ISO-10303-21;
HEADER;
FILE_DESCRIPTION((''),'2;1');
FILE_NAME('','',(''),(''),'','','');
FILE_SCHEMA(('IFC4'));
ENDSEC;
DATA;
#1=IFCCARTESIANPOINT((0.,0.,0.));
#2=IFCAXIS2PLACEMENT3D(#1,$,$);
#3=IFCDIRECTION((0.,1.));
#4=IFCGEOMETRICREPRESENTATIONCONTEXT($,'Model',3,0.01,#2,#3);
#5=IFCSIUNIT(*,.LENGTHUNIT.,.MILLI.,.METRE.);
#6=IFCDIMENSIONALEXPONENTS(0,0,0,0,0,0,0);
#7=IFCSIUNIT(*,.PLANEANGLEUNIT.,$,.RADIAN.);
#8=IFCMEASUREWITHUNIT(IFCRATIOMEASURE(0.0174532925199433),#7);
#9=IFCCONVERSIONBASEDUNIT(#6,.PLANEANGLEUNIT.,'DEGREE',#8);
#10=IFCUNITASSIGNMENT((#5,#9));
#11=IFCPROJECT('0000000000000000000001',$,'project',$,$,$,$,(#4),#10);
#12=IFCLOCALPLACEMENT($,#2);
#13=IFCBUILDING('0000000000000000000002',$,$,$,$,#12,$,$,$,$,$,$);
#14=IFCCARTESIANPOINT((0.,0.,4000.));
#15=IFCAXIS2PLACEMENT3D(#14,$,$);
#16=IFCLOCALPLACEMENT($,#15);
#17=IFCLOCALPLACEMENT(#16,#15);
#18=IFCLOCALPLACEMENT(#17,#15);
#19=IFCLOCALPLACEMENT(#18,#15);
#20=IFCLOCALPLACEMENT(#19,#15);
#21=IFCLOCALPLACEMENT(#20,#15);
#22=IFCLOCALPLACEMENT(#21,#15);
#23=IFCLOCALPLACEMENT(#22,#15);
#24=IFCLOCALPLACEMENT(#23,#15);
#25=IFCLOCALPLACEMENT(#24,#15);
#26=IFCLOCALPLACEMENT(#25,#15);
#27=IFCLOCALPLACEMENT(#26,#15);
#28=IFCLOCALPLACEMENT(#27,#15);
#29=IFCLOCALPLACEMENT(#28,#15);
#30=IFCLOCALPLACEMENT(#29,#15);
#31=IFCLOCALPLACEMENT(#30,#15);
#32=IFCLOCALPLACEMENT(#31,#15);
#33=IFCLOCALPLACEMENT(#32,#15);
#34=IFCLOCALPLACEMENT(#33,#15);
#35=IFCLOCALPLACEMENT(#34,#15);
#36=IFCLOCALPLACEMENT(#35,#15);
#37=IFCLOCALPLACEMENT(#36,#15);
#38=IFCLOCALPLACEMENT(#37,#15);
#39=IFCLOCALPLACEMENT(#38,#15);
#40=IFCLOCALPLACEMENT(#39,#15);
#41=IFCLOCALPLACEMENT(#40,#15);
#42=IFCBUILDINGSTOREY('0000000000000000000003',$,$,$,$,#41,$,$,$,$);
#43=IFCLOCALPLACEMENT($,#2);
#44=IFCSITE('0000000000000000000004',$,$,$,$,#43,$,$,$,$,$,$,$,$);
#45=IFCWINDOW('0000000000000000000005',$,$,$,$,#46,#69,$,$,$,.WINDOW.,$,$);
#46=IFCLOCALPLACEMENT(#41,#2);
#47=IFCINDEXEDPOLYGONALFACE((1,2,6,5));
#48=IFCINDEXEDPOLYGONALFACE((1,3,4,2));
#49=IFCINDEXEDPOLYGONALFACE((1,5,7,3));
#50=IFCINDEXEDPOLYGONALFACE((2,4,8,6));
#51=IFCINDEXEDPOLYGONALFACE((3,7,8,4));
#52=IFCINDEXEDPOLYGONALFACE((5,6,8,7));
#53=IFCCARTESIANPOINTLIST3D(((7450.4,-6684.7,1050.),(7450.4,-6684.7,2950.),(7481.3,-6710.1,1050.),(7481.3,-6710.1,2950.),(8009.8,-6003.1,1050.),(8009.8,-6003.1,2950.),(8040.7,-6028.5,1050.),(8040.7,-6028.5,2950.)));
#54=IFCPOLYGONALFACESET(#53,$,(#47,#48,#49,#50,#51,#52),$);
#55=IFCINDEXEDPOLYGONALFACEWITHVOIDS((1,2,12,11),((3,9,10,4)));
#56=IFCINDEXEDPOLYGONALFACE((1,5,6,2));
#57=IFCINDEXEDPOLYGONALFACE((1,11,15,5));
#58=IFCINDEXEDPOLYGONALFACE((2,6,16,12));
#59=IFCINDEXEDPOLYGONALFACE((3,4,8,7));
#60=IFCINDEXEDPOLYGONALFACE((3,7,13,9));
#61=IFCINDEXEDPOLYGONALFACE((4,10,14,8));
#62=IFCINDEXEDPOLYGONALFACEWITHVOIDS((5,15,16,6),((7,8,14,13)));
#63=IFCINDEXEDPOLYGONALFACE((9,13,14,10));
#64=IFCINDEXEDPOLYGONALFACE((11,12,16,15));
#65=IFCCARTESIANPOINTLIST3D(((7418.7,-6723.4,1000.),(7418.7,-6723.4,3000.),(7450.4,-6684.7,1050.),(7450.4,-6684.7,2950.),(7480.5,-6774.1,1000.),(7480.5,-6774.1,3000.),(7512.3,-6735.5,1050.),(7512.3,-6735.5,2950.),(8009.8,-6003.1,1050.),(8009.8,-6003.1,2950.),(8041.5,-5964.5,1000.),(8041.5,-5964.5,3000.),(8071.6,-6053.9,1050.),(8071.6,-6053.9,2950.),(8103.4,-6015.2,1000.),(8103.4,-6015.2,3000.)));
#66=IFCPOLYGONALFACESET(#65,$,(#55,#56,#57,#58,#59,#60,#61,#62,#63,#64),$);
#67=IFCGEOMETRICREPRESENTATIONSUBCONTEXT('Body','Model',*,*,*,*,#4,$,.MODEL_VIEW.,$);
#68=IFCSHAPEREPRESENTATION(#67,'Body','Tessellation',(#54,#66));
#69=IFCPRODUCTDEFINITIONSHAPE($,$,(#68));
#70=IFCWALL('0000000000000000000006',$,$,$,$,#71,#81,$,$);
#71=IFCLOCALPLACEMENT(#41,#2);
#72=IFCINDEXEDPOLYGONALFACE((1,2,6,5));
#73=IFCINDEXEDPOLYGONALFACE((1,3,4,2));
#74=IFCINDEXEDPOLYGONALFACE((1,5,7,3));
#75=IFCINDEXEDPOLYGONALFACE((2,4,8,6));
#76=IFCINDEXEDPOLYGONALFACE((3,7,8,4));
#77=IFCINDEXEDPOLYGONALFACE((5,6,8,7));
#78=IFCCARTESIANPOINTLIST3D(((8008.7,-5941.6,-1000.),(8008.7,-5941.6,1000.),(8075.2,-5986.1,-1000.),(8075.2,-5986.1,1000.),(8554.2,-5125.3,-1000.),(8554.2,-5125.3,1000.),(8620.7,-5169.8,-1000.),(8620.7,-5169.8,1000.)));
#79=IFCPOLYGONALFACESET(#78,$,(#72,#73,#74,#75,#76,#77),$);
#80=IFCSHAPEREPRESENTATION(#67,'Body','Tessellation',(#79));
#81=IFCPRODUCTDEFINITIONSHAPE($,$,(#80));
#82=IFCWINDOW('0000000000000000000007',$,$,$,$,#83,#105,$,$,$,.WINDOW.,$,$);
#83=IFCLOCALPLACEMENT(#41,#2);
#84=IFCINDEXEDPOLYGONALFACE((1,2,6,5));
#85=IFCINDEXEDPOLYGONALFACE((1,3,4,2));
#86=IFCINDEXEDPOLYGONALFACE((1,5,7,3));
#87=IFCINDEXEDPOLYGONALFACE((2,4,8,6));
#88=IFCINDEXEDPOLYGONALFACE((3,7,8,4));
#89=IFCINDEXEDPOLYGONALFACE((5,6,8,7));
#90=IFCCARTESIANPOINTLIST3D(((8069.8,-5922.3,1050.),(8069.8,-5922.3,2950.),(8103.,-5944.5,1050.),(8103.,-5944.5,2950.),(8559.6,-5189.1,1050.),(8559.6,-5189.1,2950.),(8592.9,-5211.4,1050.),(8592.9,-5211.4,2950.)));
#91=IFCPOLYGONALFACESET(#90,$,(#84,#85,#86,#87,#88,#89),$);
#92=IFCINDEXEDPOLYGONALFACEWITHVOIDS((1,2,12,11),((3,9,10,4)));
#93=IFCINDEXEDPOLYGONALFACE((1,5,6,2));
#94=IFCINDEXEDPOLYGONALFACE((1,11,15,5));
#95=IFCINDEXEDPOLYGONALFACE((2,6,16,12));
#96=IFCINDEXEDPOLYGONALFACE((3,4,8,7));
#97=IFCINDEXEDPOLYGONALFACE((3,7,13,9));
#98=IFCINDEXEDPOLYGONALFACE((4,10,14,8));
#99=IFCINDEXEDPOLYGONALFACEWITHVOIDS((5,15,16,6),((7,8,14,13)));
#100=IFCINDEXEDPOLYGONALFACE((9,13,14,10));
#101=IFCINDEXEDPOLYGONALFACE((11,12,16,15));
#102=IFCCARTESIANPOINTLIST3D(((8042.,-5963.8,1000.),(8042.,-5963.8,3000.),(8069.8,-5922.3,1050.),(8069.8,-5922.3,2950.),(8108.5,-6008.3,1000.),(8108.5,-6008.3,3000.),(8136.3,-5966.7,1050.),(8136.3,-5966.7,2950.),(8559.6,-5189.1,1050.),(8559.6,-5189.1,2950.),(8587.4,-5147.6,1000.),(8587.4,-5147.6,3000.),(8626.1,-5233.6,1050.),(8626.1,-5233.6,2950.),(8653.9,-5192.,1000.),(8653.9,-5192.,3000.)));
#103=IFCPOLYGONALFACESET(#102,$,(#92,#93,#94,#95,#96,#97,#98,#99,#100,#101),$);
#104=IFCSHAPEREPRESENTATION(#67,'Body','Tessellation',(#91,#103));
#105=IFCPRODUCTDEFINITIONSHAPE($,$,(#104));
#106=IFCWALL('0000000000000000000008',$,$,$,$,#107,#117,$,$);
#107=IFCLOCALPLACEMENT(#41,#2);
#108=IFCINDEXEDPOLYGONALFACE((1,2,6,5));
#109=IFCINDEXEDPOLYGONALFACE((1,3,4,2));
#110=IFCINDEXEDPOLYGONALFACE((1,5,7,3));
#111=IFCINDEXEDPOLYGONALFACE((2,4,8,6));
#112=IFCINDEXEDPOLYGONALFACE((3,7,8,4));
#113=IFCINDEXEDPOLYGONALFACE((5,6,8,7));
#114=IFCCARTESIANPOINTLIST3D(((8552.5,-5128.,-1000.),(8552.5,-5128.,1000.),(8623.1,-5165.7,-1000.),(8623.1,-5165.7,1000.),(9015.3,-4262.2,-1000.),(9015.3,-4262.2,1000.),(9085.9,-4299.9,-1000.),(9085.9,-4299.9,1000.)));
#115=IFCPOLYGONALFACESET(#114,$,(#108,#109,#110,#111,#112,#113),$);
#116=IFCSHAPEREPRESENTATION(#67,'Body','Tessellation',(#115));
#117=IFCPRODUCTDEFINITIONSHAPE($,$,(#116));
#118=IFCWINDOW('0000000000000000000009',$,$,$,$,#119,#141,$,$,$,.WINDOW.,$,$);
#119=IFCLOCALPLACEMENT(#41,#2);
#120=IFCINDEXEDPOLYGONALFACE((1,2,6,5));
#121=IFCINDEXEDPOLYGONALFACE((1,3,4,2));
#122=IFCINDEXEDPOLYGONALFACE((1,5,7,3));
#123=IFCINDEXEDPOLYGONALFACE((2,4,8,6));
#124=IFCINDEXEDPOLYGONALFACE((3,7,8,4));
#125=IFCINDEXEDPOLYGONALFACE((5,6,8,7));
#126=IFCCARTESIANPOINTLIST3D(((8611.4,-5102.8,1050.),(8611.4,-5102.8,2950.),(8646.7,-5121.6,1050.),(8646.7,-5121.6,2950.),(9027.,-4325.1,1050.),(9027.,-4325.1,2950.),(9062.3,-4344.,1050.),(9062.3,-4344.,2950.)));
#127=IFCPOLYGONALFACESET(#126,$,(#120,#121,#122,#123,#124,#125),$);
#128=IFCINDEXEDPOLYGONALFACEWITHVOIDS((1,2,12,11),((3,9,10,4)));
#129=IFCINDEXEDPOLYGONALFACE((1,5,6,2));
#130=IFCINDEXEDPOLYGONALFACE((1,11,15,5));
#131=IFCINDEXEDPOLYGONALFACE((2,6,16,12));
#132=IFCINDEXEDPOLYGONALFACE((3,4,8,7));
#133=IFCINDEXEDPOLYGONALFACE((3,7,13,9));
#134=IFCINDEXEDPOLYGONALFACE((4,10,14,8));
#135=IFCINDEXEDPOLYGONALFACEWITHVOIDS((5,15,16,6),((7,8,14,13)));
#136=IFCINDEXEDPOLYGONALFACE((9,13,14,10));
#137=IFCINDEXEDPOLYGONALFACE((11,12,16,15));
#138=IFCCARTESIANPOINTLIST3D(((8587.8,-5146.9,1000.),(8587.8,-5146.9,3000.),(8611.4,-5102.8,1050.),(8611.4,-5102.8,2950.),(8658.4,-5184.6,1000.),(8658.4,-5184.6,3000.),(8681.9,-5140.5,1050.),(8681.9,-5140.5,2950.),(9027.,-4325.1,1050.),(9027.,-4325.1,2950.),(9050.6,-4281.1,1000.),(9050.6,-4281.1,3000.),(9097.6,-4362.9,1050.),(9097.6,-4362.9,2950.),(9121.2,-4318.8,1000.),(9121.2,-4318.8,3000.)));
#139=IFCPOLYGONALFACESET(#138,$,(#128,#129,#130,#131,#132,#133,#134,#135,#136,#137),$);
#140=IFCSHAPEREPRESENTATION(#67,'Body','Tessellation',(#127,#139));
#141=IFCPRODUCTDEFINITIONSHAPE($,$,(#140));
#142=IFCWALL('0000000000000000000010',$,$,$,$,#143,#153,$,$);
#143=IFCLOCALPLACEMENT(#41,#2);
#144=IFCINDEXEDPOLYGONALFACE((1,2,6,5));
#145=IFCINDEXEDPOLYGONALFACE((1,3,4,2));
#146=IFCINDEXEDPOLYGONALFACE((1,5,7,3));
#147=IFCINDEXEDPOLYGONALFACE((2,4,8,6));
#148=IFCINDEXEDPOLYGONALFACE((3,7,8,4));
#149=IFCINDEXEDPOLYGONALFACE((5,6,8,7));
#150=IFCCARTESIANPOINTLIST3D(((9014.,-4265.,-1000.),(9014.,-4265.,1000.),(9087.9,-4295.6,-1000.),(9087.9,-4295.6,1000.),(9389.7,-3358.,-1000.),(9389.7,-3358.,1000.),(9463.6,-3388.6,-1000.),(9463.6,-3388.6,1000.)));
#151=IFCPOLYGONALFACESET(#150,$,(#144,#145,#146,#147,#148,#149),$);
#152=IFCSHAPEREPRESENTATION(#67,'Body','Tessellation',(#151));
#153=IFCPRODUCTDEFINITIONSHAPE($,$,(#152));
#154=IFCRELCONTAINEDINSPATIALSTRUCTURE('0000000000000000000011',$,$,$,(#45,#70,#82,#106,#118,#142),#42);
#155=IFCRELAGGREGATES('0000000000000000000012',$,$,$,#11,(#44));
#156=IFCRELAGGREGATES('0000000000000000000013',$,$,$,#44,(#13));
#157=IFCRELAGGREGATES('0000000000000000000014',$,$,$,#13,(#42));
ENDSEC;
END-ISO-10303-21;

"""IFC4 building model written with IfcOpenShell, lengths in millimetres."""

from ifc_helpers import new_model, entity, si_unit, converted_unit, direction, frame, origin, origin_2d, place, context, subcontext, project, spatial, rectangle, extrude, element, save


model = new_model("IFC4")

# Units and contexts
model_context = context("Model", 3, precision=0.01, world=origin(), true_north=direction((0.0, 1.0)))
body_context = subcontext(model_context, "Body", "Model", "MODEL_VIEW")
ifc_project = project(units=[si_unit("LENGTHUNIT", "METRE", prefix="MILLI"), converted_unit("PLANEANGLEUNIT", "DEGREE", entity("IfcRatioMeasure", 0.0174532925199433), si_unit("PLANEANGLEUNIT", "RADIAN"), dimensions=[0, 0, 0, 0, 0, 0, 0])], contexts=[model_context])

# Site, building, storey
site_placement = place(None, origin())
site = spatial("IfcSite", under=ifc_project, at=site_placement)
building_placement = place(None, origin())
building = spatial("IfcBuilding", under=site, at=building_placement)
placement_1 = place(None, frame((0.0, 0.0, 4000.0)))
placement_2 = place(placement_1, frame((0.0, 0.0, 4000.0)))
placement_3 = place(placement_2, frame((0.0, 0.0, 4000.0)))
placement_4 = place(placement_3, frame((0.0, 0.0, 4000.0)))
placement_5 = place(placement_4, frame((0.0, 0.0, 4000.0)))
placement_6 = place(placement_5, frame((0.0, 0.0, 4000.0)))
placement_7 = place(placement_6, frame((0.0, 0.0, 4000.0)))
placement_8 = place(placement_7, frame((0.0, 0.0, 4000.0)))
placement_9 = place(placement_8, frame((0.0, 0.0, 4000.0)))
placement_10 = place(placement_9, frame((0.0, 0.0, 4000.0)))
placement_11 = place(placement_10, frame((0.0, 0.0, 4000.0)))
placement_12 = place(placement_11, frame((0.0, 0.0, 4000.0)))
placement_13 = place(placement_12, frame((0.0, 0.0, 4000.0)))
placement_14 = place(placement_13, frame((0.0, 0.0, 4000.0)))
placement_15 = place(placement_14, frame((0.0, 0.0, 4000.0)))
placement_16 = place(placement_15, frame((0.0, 0.0, 4000.0)))
placement_17 = place(placement_16, frame((0.0, 0.0, 4000.0)))
placement_18 = place(placement_17, frame((0.0, 0.0, 4000.0)))
placement_19 = place(placement_18, frame((0.0, 0.0, 4000.0)))
placement_20 = place(placement_19, frame((0.0, 0.0, 4000.0)))
placement_21 = place(placement_20, frame((0.0, 0.0, 4000.0)))
placement_22 = place(placement_21, frame((0.0, 0.0, 4000.0)))
placement_23 = place(placement_22, frame((0.0, 0.0, 4000.0)))
placement_24 = place(placement_23, frame((0.0, 0.0, 4000.0)))
placement_25 = place(placement_24, frame((0.0, 0.0, 4000.0)))
storey_placement = place(placement_25, frame((0.0, 0.0, 4000.0)))
storey = spatial("IfcBuildingStorey", under=building, at=storey_placement)

# Shared definitions
cartesian_point_1 = entity("IfcCartesianPoint", [-440.9, -950.0])
shared_polyline = entity("IfcPolyline", [cartesian_point_1, entity("IfcCartesianPoint", [-440.9, 950.0]), entity("IfcCartesianPoint", [-440.9, 950.0]), entity("IfcCartesianPoint", [440.9, 950.0]), entity("IfcCartesianPoint", [440.9, 950.0]), entity("IfcCartesianPoint", [440.9, -950.0]), entity("IfcCartesianPoint", [440.9, -950.0]), entity("IfcCartesianPoint", [-440.9, -950.0]), cartesian_point_1])

# Window
window_1_placement = place(storey_placement, frame((7730.1, -6343.9, 2000.0), z_axis=(0.0, 0.0, 1.0), x_axis=(6343.931811, 7730.10538, 0.0)))
cartesian_point_2 = entity("IfcCartesianPoint", [-490.9, -1000.0])
element("IfcWindow", 1, at=window_1_placement, inside=storey, PredefinedType="WINDOW", context=body_context, shape_type="SweptSolid", body=[
    entity("IfcExtrudedAreaSolid", entity("IfcArbitraryClosedProfileDef", "AREA", None, shared_polyline), entity("IfcAxis2Placement3D", entity("IfcCartesianPoint", [0.0, 0.0, 0.0]), entity("IfcDirection", [0.0, -1.0, 0.0]), entity("IfcDirection", [1.0, 0.0, 0.0])), entity("IfcDirection", [0.0, 0.0, 1.0]), 40.0),
    entity("IfcExtrudedAreaSolid", entity("IfcArbitraryProfileDefWithVoids", "AREA", None, entity("IfcPolyline", [cartesian_point_2, entity("IfcCartesianPoint", [-490.9, 1000.0]), entity("IfcCartesianPoint", [-490.9, 1000.0]), entity("IfcCartesianPoint", [490.9, 1000.0]), entity("IfcCartesianPoint", [490.9, 1000.0]), entity("IfcCartesianPoint", [490.9, -1000.0]), entity("IfcCartesianPoint", [490.9, -1000.0]), entity("IfcCartesianPoint", [-490.9, -1000.0]), cartesian_point_2]), [shared_polyline]), entity("IfcAxis2Placement3D", entity("IfcCartesianPoint", [0.0, 0.0, 0.0]), entity("IfcDirection", [0.0, -1.0, 0.0]), entity("IfcDirection", [1.0, 0.0, 0.0])), entity("IfcDirection", [0.0, 0.0, 1.0]), 80.0),
])

# Wall
wall_1_placement = place(storey_placement, frame((8314.7, -5555.7, -1000.0), z_axis=(0.0, 0.0, 1.0), x_axis=(5555.702871, 8314.695762, 0.0)))
element("IfcWall", 2, at=wall_1_placement, inside=storey, context=body_context, shape_type="SweptSolid", body=[
    extrude(rectangle(XDim=981.7, YDim=80.0, at=origin_2d()), origin(), (0.0, 0.0, 1.0), 2000.0),
])

# Window
window_2_placement = place(storey_placement, frame((8314.7, -5555.7, 2000.0), z_axis=(0.0, 0.0, 1.0), x_axis=(5555.702871, 8314.695762, 0.0)))
cartesian_point_3 = entity("IfcCartesianPoint", [-490.9, -1000.0])
element("IfcWindow", 3, at=window_2_placement, inside=storey, PredefinedType="WINDOW", context=body_context, shape_type="SweptSolid", body=[
    entity("IfcExtrudedAreaSolid", entity("IfcArbitraryClosedProfileDef", "AREA", None, shared_polyline), entity("IfcAxis2Placement3D", entity("IfcCartesianPoint", [0.0, 0.0, 0.0]), entity("IfcDirection", [0.0, -1.0, 0.0]), entity("IfcDirection", [1.0, 0.0, 0.0])), entity("IfcDirection", [0.0, 0.0, 1.0]), 40.0),
    entity("IfcExtrudedAreaSolid", entity("IfcArbitraryProfileDefWithVoids", "AREA", None, entity("IfcPolyline", [cartesian_point_3, entity("IfcCartesianPoint", [-490.9, 1000.0]), entity("IfcCartesianPoint", [-490.9, 1000.0]), entity("IfcCartesianPoint", [490.9, 1000.0]), entity("IfcCartesianPoint", [490.9, 1000.0]), entity("IfcCartesianPoint", [490.9, -1000.0]), entity("IfcCartesianPoint", [490.9, -1000.0]), entity("IfcCartesianPoint", [-490.9, -1000.0]), cartesian_point_3]), [shared_polyline]), entity("IfcAxis2Placement3D", entity("IfcCartesianPoint", [0.0, 0.0, 0.0]), entity("IfcDirection", [0.0, -1.0, 0.0]), entity("IfcDirection", [1.0, 0.0, 0.0])), entity("IfcDirection", [0.0, 0.0, 1.0]), 80.0),
])

# Wall
wall_2_placement = place(storey_placement, frame((8819.2, -4714.0, -1000.0), z_axis=(0.0, 0.0, 1.0), x_axis=(4713.965487, 8819.213649, 0.0)))
element("IfcWall", 4, at=wall_2_placement, inside=storey, context=body_context, shape_type="SweptSolid", body=[
    extrude(rectangle(XDim=981.7, YDim=80.0, at=origin_2d()), origin(), (0.0, 0.0, 1.0), 2000.0),
])

# Window
window_3_placement = place(storey_placement, frame((8819.2, -4714.0, 2000.0), z_axis=(0.0, 0.0, 1.0), x_axis=(4713.965487, 8819.213649, 0.0)))
cartesian_point_4 = entity("IfcCartesianPoint", [-490.9, -1000.0])
element("IfcWindow", 5, at=window_3_placement, inside=storey, PredefinedType="WINDOW", context=body_context, shape_type="SweptSolid", body=[
    entity("IfcExtrudedAreaSolid", entity("IfcArbitraryClosedProfileDef", "AREA", None, shared_polyline), entity("IfcAxis2Placement3D", entity("IfcCartesianPoint", [0.0, 0.0, 0.0]), entity("IfcDirection", [0.0, -1.0, 0.0]), entity("IfcDirection", [1.0, 0.0, 0.0])), entity("IfcDirection", [0.0, 0.0, 1.0]), 40.0),
    entity("IfcExtrudedAreaSolid", entity("IfcArbitraryProfileDefWithVoids", "AREA", None, entity("IfcPolyline", [cartesian_point_4, entity("IfcCartesianPoint", [-490.9, 1000.0]), entity("IfcCartesianPoint", [-490.9, 1000.0]), entity("IfcCartesianPoint", [490.9, 1000.0]), entity("IfcCartesianPoint", [490.9, 1000.0]), entity("IfcCartesianPoint", [490.9, -1000.0]), entity("IfcCartesianPoint", [490.9, -1000.0]), entity("IfcCartesianPoint", [-490.9, -1000.0]), cartesian_point_4]), [shared_polyline]), entity("IfcAxis2Placement3D", entity("IfcCartesianPoint", [0.0, 0.0, 0.0]), entity("IfcDirection", [0.0, -1.0, 0.0]), entity("IfcDirection", [1.0, 0.0, 0.0])), entity("IfcDirection", [0.0, 0.0, 1.0]), 80.0),
])

# Wall
wall_3_placement = place(storey_placement, frame((9238.8, -3826.8, -1000.0), z_axis=(0.0, 0.0, 1.0), x_axis=(3826.834186, 9238.795382, 0.0)))
element("IfcWall", 6, at=wall_3_placement, inside=storey, context=body_context, shape_type="SweptSolid", body=[
    extrude(rectangle(XDim=981.7, YDim=80.0, at=origin_2d()), origin(), (0.0, 0.0, 1.0), 2000.0),
])

save(model, "model.ifc")
